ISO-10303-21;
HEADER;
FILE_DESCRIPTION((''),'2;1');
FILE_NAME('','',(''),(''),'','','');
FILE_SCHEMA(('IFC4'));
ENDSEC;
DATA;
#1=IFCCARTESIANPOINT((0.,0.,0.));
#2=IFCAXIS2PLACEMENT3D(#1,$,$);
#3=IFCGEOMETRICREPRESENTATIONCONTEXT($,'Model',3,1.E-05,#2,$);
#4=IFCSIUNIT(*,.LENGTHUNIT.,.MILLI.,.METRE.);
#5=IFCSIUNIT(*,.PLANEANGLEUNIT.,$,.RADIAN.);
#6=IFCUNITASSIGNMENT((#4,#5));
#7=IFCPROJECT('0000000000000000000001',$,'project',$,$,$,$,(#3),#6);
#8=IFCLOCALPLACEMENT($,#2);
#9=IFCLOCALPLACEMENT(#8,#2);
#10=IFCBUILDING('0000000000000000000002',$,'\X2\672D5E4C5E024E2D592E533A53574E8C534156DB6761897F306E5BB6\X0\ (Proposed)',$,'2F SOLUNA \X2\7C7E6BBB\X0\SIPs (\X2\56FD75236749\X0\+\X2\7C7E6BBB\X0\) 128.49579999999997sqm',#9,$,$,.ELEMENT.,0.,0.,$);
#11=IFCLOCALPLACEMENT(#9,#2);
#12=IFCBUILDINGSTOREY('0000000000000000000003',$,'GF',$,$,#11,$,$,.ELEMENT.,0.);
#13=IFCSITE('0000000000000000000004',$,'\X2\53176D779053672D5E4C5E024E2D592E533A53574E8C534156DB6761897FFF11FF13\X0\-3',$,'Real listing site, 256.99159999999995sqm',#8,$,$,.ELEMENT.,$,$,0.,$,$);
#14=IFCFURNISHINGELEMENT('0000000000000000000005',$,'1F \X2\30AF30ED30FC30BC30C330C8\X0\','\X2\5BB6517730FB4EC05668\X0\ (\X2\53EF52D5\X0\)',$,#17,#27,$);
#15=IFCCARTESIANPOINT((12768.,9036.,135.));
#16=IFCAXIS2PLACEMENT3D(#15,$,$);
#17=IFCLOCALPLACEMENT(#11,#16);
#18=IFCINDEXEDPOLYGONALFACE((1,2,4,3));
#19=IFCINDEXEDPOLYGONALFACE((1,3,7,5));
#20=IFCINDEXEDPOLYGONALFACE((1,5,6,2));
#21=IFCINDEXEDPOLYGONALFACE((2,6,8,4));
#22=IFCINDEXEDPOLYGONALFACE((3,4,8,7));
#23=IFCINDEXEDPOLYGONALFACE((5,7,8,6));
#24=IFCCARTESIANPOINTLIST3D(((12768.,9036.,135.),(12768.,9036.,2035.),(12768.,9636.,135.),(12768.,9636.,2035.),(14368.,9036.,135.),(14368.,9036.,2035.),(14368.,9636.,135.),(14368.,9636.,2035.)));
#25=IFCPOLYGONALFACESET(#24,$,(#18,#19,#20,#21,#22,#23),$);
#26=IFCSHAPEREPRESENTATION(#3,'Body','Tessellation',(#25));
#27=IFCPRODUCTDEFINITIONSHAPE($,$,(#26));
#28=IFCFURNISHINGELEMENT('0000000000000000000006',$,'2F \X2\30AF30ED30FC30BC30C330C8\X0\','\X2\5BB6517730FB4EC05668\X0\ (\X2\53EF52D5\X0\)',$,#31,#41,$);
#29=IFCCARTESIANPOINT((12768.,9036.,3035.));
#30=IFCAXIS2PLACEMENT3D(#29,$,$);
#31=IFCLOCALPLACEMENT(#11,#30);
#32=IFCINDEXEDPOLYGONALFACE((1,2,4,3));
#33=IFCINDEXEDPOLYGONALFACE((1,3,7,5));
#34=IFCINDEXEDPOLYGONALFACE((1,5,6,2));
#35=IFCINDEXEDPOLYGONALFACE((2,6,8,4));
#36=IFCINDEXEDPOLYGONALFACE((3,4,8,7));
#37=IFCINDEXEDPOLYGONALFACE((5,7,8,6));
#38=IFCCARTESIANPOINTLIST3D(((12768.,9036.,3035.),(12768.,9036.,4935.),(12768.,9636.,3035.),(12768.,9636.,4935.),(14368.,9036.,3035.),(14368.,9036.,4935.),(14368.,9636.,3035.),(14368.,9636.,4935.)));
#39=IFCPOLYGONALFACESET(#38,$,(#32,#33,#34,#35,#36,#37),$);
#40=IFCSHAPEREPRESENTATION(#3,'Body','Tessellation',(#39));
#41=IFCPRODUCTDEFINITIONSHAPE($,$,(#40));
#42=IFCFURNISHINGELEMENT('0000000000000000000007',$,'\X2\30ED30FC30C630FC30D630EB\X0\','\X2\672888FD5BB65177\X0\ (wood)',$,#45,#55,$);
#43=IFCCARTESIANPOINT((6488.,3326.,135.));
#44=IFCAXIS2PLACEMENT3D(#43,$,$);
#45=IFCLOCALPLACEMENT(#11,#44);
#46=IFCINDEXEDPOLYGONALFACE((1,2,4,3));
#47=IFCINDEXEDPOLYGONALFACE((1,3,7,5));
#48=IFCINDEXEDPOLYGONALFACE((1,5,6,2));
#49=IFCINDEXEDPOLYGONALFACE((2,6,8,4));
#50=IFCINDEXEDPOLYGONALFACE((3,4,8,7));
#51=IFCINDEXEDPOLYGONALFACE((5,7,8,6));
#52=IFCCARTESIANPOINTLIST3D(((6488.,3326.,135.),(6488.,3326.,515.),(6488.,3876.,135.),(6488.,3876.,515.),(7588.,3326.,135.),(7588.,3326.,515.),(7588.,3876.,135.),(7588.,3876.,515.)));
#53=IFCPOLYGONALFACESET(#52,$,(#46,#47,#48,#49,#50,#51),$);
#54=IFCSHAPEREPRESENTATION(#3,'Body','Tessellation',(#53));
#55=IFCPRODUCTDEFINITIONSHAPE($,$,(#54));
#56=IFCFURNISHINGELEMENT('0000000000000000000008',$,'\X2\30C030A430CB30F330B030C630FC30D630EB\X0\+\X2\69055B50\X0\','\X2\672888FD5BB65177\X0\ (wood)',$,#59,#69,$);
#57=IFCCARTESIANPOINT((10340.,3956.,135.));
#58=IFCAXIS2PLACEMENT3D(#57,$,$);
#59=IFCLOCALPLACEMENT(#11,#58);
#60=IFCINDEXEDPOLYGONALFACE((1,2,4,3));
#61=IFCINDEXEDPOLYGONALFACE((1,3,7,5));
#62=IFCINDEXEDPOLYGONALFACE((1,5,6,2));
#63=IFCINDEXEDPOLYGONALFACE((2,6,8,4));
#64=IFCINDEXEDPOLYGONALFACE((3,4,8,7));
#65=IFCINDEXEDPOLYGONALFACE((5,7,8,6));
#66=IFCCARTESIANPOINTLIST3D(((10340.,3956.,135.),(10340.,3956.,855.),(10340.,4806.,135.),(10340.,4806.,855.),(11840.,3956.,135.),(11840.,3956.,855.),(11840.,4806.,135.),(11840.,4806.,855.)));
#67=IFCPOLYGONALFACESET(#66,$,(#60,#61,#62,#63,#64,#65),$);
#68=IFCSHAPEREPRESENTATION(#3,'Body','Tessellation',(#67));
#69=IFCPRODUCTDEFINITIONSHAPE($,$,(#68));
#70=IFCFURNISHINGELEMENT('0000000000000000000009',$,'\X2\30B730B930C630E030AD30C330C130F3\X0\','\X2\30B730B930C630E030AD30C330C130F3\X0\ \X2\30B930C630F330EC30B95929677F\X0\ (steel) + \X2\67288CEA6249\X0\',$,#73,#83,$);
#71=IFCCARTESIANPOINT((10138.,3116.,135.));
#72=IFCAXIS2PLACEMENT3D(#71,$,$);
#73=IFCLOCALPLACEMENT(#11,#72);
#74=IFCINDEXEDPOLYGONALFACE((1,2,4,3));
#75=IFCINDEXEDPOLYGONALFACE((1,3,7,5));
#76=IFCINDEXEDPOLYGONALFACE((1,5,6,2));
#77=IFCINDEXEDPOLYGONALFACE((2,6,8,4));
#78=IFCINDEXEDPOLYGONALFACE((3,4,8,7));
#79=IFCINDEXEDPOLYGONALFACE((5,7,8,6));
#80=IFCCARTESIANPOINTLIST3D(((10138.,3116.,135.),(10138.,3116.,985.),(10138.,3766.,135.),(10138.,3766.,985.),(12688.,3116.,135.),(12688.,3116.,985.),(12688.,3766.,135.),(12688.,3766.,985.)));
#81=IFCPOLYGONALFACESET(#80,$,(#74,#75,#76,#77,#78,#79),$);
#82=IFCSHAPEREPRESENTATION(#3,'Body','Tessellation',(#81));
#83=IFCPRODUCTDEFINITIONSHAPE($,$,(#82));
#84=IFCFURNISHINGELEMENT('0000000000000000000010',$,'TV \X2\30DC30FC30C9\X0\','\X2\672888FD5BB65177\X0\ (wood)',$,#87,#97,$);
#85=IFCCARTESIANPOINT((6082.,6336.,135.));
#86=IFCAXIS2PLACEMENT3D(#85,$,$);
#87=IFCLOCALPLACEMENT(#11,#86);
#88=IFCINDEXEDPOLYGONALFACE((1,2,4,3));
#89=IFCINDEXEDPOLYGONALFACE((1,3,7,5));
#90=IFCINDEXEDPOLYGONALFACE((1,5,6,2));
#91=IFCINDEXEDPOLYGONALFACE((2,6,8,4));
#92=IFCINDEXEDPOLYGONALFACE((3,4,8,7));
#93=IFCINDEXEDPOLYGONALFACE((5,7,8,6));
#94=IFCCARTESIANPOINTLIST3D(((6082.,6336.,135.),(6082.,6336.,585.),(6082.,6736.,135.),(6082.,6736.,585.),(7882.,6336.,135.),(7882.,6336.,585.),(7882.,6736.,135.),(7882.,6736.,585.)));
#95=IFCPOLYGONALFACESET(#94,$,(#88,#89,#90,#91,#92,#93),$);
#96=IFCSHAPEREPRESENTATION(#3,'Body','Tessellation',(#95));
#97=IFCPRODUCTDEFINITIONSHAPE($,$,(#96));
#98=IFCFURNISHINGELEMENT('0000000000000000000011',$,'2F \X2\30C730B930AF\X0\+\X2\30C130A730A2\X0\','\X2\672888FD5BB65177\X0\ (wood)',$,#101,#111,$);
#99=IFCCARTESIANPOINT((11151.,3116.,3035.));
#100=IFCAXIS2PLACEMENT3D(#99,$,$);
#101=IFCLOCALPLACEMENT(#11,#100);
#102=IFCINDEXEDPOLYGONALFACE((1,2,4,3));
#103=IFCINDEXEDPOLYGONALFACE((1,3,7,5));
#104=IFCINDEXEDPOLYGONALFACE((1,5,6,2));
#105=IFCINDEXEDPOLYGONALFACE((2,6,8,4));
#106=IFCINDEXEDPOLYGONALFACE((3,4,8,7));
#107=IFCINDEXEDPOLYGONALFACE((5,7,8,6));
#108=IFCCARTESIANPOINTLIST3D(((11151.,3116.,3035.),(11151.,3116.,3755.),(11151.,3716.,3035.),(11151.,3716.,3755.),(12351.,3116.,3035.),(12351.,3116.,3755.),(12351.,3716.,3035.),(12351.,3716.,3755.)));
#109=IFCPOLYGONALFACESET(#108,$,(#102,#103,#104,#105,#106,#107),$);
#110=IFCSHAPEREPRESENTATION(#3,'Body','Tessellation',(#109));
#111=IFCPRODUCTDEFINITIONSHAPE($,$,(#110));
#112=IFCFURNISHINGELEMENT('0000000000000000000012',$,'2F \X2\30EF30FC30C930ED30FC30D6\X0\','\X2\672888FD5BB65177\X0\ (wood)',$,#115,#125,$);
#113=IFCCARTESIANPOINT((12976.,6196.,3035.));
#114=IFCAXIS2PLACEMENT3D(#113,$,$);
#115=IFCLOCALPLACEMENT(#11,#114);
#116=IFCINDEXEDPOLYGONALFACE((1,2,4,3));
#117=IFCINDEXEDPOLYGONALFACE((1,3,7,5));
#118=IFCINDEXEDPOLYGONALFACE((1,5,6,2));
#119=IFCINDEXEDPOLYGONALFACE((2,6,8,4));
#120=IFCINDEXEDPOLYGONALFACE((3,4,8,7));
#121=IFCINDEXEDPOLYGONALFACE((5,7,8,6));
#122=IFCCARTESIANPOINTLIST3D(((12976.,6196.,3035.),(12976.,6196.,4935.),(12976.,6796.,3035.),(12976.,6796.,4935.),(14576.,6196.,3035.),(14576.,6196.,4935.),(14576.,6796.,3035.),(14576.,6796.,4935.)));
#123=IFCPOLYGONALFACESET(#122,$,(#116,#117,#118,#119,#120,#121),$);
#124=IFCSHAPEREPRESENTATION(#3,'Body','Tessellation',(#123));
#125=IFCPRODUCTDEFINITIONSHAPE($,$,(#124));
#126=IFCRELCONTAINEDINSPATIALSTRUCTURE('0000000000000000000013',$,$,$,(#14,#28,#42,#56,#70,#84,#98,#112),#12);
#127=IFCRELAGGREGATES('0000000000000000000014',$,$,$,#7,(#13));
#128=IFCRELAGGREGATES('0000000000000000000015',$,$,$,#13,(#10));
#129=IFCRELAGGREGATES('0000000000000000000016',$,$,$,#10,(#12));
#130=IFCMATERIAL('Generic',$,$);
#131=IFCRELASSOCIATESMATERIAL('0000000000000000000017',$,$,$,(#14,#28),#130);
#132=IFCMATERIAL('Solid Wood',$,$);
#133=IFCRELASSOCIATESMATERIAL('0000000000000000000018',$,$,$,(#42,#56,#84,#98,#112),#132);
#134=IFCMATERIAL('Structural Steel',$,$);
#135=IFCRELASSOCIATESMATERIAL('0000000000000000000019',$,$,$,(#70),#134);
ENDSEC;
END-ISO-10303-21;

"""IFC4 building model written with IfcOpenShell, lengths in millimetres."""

from ifc_helpers import new_model, si_unit, frame, frame_2d, origin, place, context, project, spatial, rectangle, extrude, material, element, save


model = new_model("IFC4")

# Units and contexts
model_context = context("Model", 3, precision=1e-05, world=origin())
ifc_project = project(units=[si_unit("LENGTHUNIT", "METRE", prefix="MILLI"), si_unit("PLANEANGLEUNIT", "RADIAN")], contexts=[model_context])

# Site, building, storey
site_placement = place(None, origin())
site = spatial("IfcSite", under=ifc_project, at=site_placement, Name="北海道札幌市中央区南二十四条西１３-3", ObjectType="Real listing site, 256.99159999999995sqm", CompositionType="ELEMENT", RefElevation=0.0)
building_placement = place(site_placement, origin())
building = spatial("IfcBuilding", under=site, at=building_placement, Name="札幌市中央区南二十四条西の家 (Proposed)", ObjectType="2F SOLUNA 籾殻SIPs (国産杉+籾殻) 128.49579999999997sqm", CompositionType="ELEMENT", ElevationOfRefHeight=0.0, ElevationOfTerrain=0.0)
storey_placement = place(building_placement, origin())
storey = spatial("IfcBuildingStorey", under=building, at=storey_placement, Name="GF", CompositionType="ELEMENT", Elevation=0.0)

# Shared definitions
ifc_material_1 = material(Name="Solid Wood")

# Shared definitions
ifc_material_2 = material(Name="Generic")

# Furnishing elements
furnishing_1_placement = place(storey_placement, frame((12768.0, 9036.0, 135.0)))
element("IfcFurnishingElement", 1, at=furnishing_1_placement, inside=storey, material=ifc_material_2, Name="1F クローゼット", Description="家具・什器 (可動)", context=model_context, shape_type="SweptSolid", body=[
    extrude(rectangle(XDim=1600.0, YDim=600.0, at=frame_2d((800.0, 300.0))), frame((12768.0, 9036.0, 135.0)), (0.0, 0.0, 1.0), 1900.0),
])
furnishing_2_placement = place(storey_placement, frame((12768.0, 9036.0, 3035.0)))
element("IfcFurnishingElement", 2, at=furnishing_2_placement, inside=storey, material=ifc_material_2, Name="2F クローゼット", Description="家具・什器 (可動)", context=model_context, shape_type="SweptSolid", body=[
    extrude(rectangle(XDim=1600.0, YDim=600.0, at=frame_2d((800.0, 300.0))), frame((12768.0, 9036.0, 3035.0)), (0.0, 0.0, 1.0), 1900.0),
])
furnishing_3_placement = place(storey_placement, frame((6488.0, 3326.0, 135.0)))
element("IfcFurnishingElement", 3, at=furnishing_3_placement, inside=storey, material=ifc_material_1, Name="ローテーブル", Description="木製家具 (wood)", context=model_context, shape_type="SweptSolid", body=[
    extrude(rectangle(XDim=1100.0, YDim=550.0, at=frame_2d((550.0, 275.0))), frame((6488.0, 3326.0, 135.0)), (0.0, 0.0, 1.0), 380.0),
])
furnishing_4_placement = place(storey_placement, frame((10340.0, 3956.0, 135.0)))
element("IfcFurnishingElement", 4, at=furnishing_4_placement, inside=storey, material=ifc_material_1, Name="ダイニングテーブル+椅子", Description="木製家具 (wood)", context=model_context, shape_type="SweptSolid", body=[
    extrude(rectangle(XDim=1500.0, YDim=850.0, at=frame_2d((750.0, 425.0))), frame((10340.0, 3956.0, 135.0)), (0.0, 0.0, 1.0), 720.0),
])
ifc_material_3 = material(Name="Structural Steel")
furnishing_5_placement = place(storey_placement, frame((10138.0, 3116.0, 135.0)))
element("IfcFurnishingElement", 5, at=furnishing_5_placement, inside=storey, material=ifc_material_3, Name="システムキッチン", Description="システムキッチン ステンレス天板 (steel) + 木質扉", context=model_context, shape_type="SweptSolid", body=[
    extrude(rectangle(XDim=2550.0, YDim=650.0, at=frame_2d((1275.0, 325.0))), frame((10138.0, 3116.0, 135.0)), (0.0, 0.0, 1.0), 850.0),
])
furnishing_6_placement = place(storey_placement, frame((6082.0, 6336.0, 135.0)))
element("IfcFurnishingElement", 6, at=furnishing_6_placement, inside=storey, material=ifc_material_1, Name="TV ボード", Description="木製家具 (wood)", context=model_context, shape_type="SweptSolid", body=[
    extrude(rectangle(XDim=1800.0, YDim=400.0, at=frame_2d((900.0, 200.0))), frame((6082.0, 6336.0, 135.0)), (0.0, 0.0, 1.0), 450.0),
])
furnishing_7_placement = place(storey_placement, frame((11151.0, 3116.0, 3035.0)))
element("IfcFurnishingElement", 7, at=furnishing_7_placement, inside=storey, material=ifc_material_1, Name="2F デスク+チェア", Description="木製家具 (wood)", context=model_context, shape_type="SweptSolid", body=[
    extrude(rectangle(XDim=1200.0, YDim=600.0, at=frame_2d((600.0, 300.0))), frame((11151.0, 3116.0, 3035.0)), (0.0, 0.0, 1.0), 720.0),
])
furnishing_8_placement = place(storey_placement, frame((12976.0, 6196.0, 3035.0)))
element("IfcFurnishingElement", 8, at=furnishing_8_placement, inside=storey, material=ifc_material_1, Name="2F ワードローブ", Description="木製家具 (wood)", context=model_context, shape_type="SweptSolid", body=[
    extrude(rectangle(XDim=1600.0, YDim=600.0, at=frame_2d((800.0, 300.0))), frame((12976.0, 6196.0, 3035.0)), (0.0, 0.0, 1.0), 1900.0),
])

save(model, "model.ifc")
